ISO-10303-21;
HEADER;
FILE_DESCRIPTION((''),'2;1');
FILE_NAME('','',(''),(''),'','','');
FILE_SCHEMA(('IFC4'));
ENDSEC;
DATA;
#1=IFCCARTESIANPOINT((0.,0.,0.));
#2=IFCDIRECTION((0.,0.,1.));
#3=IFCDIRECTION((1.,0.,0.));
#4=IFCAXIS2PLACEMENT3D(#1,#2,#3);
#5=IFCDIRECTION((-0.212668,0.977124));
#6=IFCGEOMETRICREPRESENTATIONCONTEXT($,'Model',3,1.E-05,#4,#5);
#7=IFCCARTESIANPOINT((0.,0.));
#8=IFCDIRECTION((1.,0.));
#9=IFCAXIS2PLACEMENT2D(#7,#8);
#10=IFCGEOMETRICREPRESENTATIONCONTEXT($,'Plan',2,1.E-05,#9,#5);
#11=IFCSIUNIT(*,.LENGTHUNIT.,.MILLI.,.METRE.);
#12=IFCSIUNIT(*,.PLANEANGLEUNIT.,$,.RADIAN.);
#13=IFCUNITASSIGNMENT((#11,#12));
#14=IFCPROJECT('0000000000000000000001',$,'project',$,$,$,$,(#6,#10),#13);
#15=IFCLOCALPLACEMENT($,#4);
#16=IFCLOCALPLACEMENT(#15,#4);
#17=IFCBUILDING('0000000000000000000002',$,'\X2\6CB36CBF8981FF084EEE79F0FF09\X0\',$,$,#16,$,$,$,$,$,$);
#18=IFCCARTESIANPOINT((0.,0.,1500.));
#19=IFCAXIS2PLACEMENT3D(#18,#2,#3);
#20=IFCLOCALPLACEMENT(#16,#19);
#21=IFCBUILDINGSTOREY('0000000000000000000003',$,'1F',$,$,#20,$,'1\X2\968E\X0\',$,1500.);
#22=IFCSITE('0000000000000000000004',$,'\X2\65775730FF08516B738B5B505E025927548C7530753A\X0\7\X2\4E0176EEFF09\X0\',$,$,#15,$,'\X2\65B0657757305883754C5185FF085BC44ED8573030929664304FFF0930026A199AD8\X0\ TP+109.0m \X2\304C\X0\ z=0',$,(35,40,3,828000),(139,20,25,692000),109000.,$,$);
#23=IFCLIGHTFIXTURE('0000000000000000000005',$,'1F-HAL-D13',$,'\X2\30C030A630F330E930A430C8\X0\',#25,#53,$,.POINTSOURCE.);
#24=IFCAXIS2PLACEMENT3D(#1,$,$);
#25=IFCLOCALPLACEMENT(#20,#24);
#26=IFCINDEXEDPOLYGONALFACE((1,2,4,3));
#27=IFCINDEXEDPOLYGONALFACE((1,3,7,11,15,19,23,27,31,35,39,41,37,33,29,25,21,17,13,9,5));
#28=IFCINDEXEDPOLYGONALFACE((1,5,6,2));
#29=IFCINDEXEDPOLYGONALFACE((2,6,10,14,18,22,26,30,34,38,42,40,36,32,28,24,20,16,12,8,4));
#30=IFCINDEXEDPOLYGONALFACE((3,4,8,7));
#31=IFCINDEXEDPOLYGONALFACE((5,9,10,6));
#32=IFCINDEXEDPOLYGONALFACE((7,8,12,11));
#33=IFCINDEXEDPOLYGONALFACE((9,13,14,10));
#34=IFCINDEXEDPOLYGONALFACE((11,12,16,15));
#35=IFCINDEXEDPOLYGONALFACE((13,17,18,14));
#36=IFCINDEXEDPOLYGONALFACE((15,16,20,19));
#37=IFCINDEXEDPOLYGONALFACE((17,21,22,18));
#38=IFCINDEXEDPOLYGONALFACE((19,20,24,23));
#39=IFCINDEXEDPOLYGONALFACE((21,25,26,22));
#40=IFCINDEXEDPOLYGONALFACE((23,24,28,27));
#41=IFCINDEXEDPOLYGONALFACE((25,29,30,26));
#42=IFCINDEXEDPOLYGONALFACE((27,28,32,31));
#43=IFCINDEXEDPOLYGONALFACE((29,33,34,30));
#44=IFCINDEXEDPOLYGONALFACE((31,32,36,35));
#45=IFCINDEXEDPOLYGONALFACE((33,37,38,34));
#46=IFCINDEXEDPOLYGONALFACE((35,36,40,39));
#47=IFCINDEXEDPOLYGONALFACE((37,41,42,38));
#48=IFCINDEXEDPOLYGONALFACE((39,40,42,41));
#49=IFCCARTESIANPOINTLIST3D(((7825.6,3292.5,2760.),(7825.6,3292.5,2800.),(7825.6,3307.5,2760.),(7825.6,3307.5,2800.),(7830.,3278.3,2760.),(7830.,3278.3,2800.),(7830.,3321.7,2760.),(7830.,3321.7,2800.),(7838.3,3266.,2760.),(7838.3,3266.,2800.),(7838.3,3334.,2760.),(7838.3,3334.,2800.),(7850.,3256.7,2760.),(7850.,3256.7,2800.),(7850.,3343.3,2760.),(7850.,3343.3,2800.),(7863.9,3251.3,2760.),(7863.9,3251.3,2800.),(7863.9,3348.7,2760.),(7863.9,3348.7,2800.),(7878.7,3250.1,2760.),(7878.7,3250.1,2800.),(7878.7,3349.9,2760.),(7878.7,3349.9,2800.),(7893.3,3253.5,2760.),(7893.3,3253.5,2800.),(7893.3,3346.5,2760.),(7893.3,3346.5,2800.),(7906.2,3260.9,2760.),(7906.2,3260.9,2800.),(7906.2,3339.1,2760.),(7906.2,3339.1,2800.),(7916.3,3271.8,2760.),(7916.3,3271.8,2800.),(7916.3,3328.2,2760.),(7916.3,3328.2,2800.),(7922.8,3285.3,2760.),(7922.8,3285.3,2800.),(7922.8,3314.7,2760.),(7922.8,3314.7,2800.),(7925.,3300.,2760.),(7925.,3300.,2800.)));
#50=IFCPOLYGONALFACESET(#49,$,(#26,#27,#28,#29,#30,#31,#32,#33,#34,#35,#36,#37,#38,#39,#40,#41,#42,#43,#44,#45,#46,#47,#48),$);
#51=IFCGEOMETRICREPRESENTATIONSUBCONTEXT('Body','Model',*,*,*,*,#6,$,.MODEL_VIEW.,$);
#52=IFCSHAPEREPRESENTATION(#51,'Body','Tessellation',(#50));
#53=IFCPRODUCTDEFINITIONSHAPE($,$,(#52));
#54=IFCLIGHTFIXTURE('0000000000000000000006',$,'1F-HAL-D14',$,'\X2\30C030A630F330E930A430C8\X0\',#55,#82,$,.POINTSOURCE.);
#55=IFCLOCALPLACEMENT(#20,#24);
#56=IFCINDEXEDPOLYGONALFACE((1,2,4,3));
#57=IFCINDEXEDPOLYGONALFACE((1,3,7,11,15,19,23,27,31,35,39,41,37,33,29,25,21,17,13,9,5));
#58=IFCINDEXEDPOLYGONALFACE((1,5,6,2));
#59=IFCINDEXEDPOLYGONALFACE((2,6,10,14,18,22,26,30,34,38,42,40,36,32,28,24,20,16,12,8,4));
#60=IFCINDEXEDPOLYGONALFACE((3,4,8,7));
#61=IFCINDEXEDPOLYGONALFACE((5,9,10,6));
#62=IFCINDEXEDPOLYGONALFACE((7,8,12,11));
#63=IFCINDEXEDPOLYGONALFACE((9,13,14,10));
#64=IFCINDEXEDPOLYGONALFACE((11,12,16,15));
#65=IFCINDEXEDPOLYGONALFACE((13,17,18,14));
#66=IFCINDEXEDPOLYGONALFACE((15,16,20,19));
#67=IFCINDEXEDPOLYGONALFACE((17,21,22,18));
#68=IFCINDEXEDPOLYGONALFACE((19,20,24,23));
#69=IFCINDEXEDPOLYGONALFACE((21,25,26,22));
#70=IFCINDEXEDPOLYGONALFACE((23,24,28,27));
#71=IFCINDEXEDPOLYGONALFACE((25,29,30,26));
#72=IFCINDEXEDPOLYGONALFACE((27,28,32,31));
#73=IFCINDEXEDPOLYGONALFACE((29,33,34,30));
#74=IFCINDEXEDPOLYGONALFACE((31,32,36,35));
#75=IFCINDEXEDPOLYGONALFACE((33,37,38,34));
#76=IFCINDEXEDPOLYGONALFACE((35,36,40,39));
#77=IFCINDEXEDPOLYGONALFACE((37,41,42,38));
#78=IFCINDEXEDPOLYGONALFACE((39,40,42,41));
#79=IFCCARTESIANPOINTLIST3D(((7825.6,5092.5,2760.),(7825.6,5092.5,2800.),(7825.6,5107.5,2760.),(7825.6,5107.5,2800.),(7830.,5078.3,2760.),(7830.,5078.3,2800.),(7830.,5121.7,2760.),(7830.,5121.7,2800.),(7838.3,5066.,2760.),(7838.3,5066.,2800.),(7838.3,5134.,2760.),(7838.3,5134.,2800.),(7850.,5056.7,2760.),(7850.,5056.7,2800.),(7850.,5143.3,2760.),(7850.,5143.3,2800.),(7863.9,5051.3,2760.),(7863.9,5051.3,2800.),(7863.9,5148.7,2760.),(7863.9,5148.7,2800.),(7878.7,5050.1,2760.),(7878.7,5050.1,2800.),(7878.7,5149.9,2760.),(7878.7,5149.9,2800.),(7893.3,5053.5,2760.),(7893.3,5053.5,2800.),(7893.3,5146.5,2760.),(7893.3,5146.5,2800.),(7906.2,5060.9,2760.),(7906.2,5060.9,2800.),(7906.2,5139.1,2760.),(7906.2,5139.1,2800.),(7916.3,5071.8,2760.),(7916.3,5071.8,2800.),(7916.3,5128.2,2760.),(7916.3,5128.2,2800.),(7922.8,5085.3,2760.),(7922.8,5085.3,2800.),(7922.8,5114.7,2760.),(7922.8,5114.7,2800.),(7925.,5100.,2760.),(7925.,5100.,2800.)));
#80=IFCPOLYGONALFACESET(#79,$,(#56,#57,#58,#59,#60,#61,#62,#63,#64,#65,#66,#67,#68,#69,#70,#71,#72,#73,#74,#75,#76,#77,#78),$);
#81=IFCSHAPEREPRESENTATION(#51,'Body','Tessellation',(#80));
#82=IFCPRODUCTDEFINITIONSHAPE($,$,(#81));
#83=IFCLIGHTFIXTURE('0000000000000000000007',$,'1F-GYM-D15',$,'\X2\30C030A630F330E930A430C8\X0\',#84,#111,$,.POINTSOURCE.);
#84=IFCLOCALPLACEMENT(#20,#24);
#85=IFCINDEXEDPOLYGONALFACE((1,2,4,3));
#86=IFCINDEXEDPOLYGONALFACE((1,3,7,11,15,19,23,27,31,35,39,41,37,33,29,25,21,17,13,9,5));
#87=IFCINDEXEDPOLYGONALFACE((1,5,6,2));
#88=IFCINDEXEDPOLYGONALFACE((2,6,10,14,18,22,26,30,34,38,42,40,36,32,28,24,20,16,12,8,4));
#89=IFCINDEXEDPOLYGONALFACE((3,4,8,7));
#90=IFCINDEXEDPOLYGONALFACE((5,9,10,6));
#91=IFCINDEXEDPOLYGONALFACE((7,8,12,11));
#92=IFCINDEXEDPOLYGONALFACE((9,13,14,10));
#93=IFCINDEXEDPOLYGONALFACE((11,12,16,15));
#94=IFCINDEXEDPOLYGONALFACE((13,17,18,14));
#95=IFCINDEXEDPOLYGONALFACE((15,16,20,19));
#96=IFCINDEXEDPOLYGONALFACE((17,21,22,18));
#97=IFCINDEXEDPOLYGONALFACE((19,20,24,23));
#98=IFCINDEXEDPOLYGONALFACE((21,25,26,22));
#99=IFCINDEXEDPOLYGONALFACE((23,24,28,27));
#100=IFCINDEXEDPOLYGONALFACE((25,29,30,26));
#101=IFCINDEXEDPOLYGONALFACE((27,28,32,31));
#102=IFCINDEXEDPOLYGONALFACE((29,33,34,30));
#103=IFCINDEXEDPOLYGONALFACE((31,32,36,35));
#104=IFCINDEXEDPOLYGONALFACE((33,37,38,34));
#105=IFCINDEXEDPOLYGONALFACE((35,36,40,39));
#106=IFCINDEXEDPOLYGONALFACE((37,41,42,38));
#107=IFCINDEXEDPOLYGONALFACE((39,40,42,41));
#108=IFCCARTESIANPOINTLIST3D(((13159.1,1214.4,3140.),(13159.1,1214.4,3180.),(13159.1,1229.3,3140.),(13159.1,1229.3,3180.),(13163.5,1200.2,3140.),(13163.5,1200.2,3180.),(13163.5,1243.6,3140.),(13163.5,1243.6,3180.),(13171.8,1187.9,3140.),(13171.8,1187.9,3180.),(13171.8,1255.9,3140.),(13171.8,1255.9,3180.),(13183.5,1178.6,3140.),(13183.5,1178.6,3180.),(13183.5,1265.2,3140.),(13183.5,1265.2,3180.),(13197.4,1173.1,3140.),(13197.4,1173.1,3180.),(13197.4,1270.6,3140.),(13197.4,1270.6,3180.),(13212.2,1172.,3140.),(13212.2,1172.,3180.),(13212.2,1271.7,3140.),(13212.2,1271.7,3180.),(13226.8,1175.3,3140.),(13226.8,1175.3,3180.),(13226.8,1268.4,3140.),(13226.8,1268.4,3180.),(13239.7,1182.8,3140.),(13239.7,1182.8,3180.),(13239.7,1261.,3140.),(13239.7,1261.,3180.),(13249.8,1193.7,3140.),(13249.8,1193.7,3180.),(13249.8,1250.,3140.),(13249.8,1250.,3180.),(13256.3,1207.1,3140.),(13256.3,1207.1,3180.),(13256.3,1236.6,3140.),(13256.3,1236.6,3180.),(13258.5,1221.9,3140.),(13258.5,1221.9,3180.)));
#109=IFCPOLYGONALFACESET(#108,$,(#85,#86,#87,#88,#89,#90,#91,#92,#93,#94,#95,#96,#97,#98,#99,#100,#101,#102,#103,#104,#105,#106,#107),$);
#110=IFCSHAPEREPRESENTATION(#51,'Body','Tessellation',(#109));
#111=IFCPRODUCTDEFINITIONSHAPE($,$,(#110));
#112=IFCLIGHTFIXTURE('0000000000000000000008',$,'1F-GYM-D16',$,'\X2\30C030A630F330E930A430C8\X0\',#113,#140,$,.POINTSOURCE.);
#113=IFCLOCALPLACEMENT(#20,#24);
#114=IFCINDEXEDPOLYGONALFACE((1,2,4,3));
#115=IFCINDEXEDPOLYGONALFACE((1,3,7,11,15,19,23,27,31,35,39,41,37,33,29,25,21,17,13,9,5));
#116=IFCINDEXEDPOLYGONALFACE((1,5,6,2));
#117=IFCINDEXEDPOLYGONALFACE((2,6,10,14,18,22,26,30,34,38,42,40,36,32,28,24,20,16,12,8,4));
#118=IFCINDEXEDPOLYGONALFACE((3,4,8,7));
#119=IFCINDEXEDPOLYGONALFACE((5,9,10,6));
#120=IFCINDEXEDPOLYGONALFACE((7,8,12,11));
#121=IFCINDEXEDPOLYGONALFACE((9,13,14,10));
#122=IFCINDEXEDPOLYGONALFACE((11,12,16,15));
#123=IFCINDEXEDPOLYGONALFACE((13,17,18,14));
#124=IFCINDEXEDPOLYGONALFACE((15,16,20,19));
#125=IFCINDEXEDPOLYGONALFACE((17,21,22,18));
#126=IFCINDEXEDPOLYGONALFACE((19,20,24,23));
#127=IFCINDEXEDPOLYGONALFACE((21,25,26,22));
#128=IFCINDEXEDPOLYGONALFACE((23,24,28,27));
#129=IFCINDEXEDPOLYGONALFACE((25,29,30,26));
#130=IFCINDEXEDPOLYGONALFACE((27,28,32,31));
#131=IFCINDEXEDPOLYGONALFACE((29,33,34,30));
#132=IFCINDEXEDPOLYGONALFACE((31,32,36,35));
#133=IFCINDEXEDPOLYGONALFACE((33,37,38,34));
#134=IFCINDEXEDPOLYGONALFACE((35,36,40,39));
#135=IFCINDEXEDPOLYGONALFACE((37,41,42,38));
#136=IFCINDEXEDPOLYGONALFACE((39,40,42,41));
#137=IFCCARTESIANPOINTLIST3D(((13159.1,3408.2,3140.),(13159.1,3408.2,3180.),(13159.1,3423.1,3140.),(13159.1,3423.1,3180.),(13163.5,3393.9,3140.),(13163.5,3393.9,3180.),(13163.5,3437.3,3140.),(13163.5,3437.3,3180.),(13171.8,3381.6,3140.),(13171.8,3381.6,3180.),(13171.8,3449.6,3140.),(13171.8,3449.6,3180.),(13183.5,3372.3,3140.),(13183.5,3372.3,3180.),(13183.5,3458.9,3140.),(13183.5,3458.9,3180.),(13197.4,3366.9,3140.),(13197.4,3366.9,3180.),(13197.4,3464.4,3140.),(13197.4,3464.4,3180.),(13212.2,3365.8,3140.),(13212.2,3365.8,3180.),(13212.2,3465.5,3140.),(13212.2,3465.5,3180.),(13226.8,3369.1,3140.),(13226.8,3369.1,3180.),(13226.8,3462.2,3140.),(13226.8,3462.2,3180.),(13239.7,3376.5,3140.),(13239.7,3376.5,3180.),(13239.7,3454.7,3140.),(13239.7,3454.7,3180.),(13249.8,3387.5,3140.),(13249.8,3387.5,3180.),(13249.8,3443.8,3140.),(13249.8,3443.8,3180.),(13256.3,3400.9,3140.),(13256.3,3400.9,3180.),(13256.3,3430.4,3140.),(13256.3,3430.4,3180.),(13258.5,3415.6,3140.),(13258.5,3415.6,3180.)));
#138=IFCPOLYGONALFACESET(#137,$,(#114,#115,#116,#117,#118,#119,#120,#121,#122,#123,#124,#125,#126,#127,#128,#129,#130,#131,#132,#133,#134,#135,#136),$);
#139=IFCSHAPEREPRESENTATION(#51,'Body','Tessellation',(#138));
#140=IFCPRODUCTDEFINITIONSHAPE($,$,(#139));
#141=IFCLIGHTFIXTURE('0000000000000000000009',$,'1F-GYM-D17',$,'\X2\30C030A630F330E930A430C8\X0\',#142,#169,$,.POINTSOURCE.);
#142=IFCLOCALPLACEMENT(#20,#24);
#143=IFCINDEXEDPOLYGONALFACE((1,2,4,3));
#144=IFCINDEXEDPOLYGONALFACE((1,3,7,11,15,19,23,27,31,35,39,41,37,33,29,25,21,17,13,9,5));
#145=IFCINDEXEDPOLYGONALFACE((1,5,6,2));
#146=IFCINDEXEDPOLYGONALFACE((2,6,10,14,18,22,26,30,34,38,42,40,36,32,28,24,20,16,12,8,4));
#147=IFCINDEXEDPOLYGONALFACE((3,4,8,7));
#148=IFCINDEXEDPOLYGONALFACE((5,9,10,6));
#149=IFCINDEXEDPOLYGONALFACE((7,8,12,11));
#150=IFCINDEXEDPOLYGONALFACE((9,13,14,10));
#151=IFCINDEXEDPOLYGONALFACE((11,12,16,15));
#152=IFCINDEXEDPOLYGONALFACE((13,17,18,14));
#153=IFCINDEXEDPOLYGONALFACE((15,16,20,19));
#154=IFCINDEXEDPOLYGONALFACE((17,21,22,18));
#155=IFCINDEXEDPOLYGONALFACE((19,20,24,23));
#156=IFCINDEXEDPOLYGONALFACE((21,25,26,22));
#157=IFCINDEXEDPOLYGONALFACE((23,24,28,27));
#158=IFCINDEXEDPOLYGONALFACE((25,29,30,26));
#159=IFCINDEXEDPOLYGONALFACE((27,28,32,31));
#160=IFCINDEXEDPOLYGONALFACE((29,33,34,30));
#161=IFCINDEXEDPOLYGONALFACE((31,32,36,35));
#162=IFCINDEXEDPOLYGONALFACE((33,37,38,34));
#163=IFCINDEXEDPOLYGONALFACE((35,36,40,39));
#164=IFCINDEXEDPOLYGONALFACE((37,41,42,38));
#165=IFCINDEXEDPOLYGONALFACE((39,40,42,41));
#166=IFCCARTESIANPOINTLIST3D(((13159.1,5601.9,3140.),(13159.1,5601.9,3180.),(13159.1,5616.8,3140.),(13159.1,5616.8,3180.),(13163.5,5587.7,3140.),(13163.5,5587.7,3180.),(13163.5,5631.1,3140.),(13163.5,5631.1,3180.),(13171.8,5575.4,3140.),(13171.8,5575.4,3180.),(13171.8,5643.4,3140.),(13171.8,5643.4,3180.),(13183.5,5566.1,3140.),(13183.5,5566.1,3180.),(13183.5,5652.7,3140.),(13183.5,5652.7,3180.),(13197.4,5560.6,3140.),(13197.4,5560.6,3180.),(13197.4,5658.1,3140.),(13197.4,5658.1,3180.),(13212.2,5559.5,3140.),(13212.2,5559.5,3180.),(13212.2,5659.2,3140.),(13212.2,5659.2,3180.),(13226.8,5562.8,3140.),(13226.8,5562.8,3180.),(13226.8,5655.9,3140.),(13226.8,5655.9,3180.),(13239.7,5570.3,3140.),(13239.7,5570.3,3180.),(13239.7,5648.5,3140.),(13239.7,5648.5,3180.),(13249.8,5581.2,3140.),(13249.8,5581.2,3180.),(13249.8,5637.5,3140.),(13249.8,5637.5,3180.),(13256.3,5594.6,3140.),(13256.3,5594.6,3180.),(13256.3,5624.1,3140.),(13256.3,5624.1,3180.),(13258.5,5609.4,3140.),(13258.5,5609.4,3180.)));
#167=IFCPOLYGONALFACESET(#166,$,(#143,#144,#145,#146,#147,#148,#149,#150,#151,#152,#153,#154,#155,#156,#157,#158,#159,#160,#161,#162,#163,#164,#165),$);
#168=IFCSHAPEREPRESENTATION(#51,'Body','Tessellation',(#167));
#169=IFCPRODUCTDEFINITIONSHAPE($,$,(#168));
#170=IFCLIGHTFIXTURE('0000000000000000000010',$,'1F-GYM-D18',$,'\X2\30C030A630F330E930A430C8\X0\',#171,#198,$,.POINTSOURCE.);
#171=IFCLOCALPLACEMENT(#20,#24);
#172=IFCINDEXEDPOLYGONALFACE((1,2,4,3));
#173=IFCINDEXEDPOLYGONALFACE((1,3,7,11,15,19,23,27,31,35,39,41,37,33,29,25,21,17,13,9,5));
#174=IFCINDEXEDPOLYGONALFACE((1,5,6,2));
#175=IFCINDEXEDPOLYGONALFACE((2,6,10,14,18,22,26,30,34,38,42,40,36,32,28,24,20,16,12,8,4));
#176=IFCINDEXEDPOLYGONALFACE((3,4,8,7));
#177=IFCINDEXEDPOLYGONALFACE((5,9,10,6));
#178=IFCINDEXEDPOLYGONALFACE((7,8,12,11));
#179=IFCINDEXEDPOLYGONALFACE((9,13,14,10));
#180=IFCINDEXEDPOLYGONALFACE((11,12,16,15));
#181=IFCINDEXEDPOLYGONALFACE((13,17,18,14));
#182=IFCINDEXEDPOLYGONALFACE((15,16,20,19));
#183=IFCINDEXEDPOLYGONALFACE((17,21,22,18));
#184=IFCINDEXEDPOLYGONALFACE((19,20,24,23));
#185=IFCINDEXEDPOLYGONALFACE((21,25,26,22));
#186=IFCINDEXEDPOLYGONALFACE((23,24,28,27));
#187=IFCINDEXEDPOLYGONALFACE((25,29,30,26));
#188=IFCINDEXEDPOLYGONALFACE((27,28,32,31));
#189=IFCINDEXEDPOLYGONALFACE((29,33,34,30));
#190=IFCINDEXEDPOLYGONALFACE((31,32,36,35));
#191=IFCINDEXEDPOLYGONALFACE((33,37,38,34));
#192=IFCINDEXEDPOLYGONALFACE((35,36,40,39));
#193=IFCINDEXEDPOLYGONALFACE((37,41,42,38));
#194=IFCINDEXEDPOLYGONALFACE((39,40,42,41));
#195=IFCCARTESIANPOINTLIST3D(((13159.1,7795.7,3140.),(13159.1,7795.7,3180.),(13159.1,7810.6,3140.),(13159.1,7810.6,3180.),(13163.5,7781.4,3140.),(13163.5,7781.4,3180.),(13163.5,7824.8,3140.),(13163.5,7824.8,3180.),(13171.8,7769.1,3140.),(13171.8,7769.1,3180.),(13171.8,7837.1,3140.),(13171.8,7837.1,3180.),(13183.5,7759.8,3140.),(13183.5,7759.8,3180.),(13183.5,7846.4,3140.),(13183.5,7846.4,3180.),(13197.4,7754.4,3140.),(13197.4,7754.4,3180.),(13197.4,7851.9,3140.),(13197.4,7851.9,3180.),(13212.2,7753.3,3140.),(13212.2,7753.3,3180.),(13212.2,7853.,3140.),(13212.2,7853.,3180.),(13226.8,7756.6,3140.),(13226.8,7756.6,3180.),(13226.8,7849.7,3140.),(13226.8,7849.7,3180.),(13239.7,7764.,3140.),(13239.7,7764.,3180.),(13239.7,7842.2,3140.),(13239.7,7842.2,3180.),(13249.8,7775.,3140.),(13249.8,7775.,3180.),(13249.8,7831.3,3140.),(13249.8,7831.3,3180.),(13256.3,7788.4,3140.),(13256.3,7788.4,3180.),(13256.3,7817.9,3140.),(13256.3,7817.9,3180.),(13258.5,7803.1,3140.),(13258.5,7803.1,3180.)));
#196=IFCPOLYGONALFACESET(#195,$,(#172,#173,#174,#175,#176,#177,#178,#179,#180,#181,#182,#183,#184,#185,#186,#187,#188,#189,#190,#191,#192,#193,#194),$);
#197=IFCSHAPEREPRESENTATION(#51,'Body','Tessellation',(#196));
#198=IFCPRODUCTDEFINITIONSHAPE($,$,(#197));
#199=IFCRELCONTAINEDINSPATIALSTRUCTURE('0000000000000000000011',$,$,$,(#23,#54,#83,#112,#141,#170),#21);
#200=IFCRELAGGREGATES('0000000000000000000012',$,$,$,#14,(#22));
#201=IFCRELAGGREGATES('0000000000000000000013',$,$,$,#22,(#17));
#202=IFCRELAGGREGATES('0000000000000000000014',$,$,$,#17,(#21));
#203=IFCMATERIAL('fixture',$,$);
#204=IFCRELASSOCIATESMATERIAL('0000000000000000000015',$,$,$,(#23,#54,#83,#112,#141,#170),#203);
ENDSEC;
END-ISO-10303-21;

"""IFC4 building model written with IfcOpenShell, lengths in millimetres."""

from ifc_helpers import new_model, si_unit, direction, frame, frame_2d, origin_with_axes, origin_2d_with_axis, place, context, subcontext, project, spatial, circle, extrude, material, element, save


model = new_model("IFC4")

# Units and contexts
model_context = context("Model", 3, precision=1e-05, world=origin_with_axes(), true_north=direction((-0.212668, 0.977124)))
plan_context = context("Plan", 2, precision=1e-05, world=origin_2d_with_axis(), true_north=direction((-0.212668, 0.977124)))
body_context = subcontext(model_context, "Body", "Model", "MODEL_VIEW")
ifc_project = project(units=[si_unit("LENGTHUNIT", "METRE", prefix="MILLI"), si_unit("PLANEANGLEUNIT", "RADIAN")], contexts=[model_context, plan_context])

# Site, building, storey
site_placement = place(None, origin_with_axes())
site = spatial("IfcSite", under=ifc_project, at=site_placement, Name="敷地（八王子市大和田町7丁目）", LongName="新敷地境界内（寄付地を除く）。標高 TP+109.0m が z=0", RefLatitude=(35, 40, 3, 828000), RefLongitude=(139, 20, 25, 692000), RefElevation=109000.0)
building_placement = place(site_placement, origin_with_axes())
building = spatial("IfcBuilding", under=site, at=building_placement, Name="河沿要（仮称）")
storey_placement = place(building_placement, frame((0.0, 0.0, 1500.0), z_axis=(0.0, 0.0, 1.0), x_axis=(1.0, 0.0, 0.0)))
storey = spatial("IfcBuildingStorey", under=building, at=storey_placement, Name="1F", LongName="1階", Elevation=1500.0)

# Light fixtures
ifc_material = material(Name="fixture")
light_fixture_1_placement = place(storey_placement, origin_with_axes())
element("IfcLightFixture", 1, at=light_fixture_1_placement, inside=storey, material=ifc_material, Name="1F-HAL-D13", ObjectType="ダウンライト", PredefinedType="POINTSOURCE", context=body_context, shape_type="SweptSolid", body=[
    extrude(circle(Radius=50.0, at=frame_2d((7875.0, 3300.0))), frame((0.0, 0.0, 2760.0)), (0.0, 0.0, 1.0), 40.0),
])
light_fixture_2_placement = place(storey_placement, origin_with_axes())
element("IfcLightFixture", 2, at=light_fixture_2_placement, inside=storey, material=ifc_material, Name="1F-HAL-D14", ObjectType="ダウンライト", PredefinedType="POINTSOURCE", context=body_context, shape_type="SweptSolid", body=[
    extrude(circle(Radius=50.0, at=frame_2d((7875.0, 5100.0))), frame((0.0, 0.0, 2760.0)), (0.0, 0.0, 1.0), 40.0),
])
light_fixture_3_placement = place(storey_placement, origin_with_axes())
element("IfcLightFixture", 3, at=light_fixture_3_placement, inside=storey, material=ifc_material, Name="1F-GYM-D15", ObjectType="ダウンライト", PredefinedType="POINTSOURCE", context=body_context, shape_type="SweptSolid", body=[
    extrude(circle(Radius=50.0, at=frame_2d((13208.5, 1221.9))), frame((0.0, 0.0, 3140.0)), (0.0, 0.0, 1.0), 40.0),
])
light_fixture_4_placement = place(storey_placement, origin_with_axes())
element("IfcLightFixture", 4, at=light_fixture_4_placement, inside=storey, material=ifc_material, Name="1F-GYM-D16", ObjectType="ダウンライト", PredefinedType="POINTSOURCE", context=body_context, shape_type="SweptSolid", body=[
    extrude(circle(Radius=50.0, at=frame_2d((13208.5, 3415.6))), frame((0.0, 0.0, 3140.0)), (0.0, 0.0, 1.0), 40.0),
])
light_fixture_5_placement = place(storey_placement, origin_with_axes())
element("IfcLightFixture", 5, at=light_fixture_5_placement, inside=storey, material=ifc_material, Name="1F-GYM-D17", ObjectType="ダウンライト", PredefinedType="POINTSOURCE", context=body_context, shape_type="SweptSolid", body=[
    extrude(circle(Radius=50.0, at=frame_2d((13208.5, 5609.4))), frame((0.0, 0.0, 3140.0)), (0.0, 0.0, 1.0), 40.0),
])
light_fixture_6_placement = place(storey_placement, origin_with_axes())
element("IfcLightFixture", 6, at=light_fixture_6_placement, inside=storey, material=ifc_material, Name="1F-GYM-D18", ObjectType="ダウンライト", PredefinedType="POINTSOURCE", context=body_context, shape_type="SweptSolid", body=[
    extrude(circle(Radius=50.0, at=frame_2d((13208.5, 7803.1))), frame((0.0, 0.0, 3140.0)), (0.0, 0.0, 1.0), 40.0),
])

save(model, "model.ifc")
